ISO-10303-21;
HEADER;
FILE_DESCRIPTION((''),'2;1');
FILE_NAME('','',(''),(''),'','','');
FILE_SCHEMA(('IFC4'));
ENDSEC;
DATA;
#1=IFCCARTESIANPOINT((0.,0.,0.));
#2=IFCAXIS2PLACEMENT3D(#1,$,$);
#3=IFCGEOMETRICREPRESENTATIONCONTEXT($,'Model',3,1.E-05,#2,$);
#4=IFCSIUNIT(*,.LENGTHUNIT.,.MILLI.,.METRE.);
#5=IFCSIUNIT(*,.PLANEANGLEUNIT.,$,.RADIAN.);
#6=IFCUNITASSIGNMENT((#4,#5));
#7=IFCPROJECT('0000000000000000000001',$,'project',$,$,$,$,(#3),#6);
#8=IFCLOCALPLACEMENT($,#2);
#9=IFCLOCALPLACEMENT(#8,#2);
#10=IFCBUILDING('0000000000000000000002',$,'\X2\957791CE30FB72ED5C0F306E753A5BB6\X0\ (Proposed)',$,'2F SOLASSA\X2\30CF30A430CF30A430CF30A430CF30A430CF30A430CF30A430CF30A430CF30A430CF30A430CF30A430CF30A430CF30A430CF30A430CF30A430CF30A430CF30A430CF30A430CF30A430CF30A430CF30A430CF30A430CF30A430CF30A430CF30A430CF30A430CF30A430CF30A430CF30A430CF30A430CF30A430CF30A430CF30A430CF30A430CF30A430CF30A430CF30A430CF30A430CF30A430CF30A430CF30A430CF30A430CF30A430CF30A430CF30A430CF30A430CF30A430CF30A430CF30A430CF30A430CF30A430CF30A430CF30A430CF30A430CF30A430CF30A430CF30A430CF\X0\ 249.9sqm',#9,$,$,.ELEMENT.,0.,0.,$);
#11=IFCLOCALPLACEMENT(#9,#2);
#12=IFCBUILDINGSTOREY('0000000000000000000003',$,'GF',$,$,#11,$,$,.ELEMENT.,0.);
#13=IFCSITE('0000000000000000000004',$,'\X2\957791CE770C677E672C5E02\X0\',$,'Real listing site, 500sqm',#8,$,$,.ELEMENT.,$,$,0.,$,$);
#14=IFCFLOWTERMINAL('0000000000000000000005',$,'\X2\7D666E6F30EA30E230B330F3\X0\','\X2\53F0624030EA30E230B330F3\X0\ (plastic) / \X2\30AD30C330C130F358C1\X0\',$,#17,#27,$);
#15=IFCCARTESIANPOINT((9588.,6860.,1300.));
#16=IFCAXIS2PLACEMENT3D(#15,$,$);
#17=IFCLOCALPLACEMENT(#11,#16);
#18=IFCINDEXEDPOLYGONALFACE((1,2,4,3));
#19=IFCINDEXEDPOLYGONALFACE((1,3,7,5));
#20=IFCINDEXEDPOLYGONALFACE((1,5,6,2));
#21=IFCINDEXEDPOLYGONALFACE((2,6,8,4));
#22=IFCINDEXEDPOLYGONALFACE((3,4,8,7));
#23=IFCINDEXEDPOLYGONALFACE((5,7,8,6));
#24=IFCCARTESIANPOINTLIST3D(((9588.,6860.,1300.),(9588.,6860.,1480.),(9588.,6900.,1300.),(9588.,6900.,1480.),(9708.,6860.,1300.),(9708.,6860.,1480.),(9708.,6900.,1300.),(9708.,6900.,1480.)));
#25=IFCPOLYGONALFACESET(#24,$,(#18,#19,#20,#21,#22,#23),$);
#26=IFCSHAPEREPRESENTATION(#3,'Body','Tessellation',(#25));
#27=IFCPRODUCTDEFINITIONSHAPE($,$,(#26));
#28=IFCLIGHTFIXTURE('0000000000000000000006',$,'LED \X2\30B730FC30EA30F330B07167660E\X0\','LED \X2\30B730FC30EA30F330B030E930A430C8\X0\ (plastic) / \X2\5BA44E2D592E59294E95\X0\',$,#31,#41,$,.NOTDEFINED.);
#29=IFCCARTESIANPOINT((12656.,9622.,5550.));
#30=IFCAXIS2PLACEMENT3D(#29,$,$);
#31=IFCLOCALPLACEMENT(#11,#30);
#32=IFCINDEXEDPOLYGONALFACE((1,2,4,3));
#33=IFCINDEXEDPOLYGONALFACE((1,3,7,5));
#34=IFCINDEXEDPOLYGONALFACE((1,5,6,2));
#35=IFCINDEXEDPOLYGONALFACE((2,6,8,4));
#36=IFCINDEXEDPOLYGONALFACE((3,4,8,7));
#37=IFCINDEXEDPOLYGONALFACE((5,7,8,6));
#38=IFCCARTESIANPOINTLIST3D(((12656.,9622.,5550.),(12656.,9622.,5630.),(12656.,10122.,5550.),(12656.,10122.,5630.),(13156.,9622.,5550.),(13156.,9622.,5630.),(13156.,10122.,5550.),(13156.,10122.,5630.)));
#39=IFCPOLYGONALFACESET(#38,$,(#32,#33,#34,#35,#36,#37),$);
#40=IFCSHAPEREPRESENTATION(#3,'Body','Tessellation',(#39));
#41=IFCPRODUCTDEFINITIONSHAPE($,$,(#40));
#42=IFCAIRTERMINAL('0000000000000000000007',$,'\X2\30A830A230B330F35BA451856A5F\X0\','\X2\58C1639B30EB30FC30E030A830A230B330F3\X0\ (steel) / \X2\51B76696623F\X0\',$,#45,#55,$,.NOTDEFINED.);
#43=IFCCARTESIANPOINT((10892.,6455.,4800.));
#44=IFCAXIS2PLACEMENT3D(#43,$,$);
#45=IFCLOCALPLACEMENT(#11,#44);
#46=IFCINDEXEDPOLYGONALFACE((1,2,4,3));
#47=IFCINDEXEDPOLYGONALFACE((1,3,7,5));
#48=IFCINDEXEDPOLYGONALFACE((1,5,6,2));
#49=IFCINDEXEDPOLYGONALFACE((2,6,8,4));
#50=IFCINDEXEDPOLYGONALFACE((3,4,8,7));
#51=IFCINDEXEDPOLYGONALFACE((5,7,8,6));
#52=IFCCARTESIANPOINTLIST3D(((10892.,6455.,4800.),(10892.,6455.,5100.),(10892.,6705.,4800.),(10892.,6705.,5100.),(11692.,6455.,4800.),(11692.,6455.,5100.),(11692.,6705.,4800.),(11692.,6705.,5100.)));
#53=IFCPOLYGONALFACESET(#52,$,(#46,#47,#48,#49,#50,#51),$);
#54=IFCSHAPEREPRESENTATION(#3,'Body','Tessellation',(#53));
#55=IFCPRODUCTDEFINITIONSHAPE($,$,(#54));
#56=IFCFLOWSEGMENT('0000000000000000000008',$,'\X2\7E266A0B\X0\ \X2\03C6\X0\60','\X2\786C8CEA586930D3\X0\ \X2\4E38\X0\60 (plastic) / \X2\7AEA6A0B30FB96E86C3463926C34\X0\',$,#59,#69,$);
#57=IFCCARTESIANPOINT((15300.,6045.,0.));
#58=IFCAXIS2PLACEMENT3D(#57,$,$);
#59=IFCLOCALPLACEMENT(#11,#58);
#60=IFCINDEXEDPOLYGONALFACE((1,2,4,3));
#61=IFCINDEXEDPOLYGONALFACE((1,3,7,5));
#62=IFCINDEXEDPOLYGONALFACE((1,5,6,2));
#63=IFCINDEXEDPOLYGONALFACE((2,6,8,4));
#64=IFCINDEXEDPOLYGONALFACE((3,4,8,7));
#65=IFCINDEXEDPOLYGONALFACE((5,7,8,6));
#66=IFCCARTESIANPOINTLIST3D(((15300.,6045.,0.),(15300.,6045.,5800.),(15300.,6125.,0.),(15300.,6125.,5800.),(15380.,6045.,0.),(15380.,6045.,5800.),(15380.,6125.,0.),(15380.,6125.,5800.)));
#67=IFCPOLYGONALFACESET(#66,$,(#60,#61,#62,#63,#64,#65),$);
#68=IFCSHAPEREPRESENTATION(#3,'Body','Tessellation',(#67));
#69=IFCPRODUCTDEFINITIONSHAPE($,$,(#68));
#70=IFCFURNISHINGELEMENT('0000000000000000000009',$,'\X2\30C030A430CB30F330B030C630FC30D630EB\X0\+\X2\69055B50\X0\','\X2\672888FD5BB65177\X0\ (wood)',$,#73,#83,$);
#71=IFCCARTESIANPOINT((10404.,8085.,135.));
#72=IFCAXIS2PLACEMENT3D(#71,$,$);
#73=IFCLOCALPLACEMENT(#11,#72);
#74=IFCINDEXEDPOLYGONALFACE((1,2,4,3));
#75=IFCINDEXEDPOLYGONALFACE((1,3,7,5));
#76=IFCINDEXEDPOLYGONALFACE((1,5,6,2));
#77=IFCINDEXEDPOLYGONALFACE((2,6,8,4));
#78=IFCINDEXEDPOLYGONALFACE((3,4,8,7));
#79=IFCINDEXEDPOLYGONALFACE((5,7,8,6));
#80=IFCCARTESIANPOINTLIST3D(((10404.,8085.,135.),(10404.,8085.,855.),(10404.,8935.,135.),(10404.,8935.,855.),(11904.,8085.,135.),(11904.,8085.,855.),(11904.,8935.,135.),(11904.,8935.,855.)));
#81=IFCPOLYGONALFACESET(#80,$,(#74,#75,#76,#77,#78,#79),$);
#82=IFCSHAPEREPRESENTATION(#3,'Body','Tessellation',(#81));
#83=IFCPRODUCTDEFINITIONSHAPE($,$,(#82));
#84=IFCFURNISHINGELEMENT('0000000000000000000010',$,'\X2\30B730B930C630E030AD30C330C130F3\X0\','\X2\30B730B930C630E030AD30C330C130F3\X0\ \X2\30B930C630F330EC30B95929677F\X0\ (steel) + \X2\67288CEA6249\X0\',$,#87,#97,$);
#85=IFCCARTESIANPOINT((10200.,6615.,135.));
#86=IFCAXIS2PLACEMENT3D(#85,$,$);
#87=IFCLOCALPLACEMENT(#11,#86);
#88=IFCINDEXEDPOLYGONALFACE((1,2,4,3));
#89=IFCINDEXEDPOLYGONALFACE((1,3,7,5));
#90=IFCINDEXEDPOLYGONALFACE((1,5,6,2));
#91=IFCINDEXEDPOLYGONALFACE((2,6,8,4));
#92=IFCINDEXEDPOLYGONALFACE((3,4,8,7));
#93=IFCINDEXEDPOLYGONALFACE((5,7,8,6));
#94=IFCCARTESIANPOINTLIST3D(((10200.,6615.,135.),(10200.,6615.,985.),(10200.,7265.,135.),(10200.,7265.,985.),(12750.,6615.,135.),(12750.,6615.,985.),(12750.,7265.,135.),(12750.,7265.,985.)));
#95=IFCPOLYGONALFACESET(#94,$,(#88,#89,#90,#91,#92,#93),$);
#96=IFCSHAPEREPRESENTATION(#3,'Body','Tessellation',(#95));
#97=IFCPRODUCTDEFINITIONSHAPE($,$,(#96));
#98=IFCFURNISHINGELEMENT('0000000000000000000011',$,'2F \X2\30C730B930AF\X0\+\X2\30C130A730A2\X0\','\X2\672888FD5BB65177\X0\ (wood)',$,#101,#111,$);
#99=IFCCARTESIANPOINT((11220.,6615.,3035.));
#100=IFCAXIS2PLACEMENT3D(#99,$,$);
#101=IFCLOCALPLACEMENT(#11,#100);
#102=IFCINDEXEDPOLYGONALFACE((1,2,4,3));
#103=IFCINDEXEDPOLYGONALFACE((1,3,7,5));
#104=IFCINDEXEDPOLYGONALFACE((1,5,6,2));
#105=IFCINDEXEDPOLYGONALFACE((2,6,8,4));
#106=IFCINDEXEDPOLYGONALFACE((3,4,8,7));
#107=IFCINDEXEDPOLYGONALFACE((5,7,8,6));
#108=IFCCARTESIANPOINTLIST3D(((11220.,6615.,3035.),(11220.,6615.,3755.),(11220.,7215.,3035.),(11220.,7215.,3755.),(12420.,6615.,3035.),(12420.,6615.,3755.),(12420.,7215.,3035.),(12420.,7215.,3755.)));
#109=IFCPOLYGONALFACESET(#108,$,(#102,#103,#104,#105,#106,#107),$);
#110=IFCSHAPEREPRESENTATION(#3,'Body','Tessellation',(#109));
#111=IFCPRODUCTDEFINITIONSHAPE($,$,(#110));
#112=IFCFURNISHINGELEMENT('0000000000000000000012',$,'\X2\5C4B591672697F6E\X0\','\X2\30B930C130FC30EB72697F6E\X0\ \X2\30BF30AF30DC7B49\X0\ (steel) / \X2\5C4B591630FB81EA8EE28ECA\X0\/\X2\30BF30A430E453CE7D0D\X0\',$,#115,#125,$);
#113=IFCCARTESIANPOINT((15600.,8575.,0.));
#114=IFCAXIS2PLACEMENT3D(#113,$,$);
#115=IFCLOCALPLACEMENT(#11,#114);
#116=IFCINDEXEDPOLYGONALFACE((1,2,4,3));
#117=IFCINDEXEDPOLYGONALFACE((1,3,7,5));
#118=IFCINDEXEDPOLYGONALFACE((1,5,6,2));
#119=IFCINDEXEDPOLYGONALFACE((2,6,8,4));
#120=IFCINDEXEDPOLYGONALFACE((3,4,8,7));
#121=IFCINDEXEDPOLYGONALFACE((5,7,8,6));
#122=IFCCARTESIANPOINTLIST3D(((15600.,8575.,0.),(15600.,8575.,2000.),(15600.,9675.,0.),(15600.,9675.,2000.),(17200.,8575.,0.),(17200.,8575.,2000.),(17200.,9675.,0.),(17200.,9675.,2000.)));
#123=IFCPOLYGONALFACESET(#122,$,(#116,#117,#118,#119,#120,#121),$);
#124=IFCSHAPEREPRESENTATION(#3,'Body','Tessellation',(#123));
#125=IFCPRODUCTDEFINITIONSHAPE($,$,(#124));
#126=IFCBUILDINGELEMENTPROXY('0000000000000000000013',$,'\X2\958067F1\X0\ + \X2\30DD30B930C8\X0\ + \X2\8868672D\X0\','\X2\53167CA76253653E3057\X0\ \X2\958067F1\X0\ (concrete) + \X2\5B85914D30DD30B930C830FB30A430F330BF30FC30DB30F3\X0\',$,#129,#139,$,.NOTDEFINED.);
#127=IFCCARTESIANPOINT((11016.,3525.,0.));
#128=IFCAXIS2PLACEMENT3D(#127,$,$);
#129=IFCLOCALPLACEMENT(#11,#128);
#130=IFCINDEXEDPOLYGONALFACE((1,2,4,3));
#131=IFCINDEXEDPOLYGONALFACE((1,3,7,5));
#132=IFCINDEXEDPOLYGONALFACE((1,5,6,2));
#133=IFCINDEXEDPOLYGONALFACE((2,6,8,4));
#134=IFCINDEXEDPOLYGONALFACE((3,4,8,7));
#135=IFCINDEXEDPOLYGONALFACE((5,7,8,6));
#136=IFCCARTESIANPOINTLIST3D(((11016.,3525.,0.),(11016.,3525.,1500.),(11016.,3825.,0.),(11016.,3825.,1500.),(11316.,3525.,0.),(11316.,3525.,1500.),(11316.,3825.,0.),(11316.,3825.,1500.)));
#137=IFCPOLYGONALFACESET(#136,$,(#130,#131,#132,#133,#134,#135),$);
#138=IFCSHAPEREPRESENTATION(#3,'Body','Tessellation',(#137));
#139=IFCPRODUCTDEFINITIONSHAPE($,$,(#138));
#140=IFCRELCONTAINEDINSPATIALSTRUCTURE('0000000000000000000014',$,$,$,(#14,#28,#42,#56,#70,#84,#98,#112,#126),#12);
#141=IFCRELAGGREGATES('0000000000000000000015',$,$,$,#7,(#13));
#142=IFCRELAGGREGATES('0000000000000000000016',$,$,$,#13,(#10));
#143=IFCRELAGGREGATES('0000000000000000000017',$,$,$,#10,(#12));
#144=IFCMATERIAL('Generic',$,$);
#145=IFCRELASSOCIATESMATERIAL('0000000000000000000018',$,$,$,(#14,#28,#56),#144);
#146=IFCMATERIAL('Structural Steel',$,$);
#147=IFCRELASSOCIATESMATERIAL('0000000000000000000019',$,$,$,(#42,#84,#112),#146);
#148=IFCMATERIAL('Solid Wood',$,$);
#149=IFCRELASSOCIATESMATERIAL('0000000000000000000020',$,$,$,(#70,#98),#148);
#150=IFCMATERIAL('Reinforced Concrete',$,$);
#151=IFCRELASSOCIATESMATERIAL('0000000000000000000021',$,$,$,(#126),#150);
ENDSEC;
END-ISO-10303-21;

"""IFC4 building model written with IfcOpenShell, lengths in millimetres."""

from ifc_helpers import new_model, si_unit, frame, frame_2d, origin, place, context, project, spatial, rectangle, extrude, material, element, save


model = new_model("IFC4")

# Units and contexts
model_context = context("Model", 3, precision=1e-05, world=origin())
ifc_project = project(units=[si_unit("LENGTHUNIT", "METRE", prefix="MILLI"), si_unit("PLANEANGLEUNIT", "RADIAN")], contexts=[model_context])

# Site, building, storey
site_placement = place(None, origin())
site = spatial("IfcSite", under=ifc_project, at=site_placement, Name="長野県松本市", ObjectType="Real listing site, 500sqm", CompositionType="ELEMENT", RefElevation=0.0)
building_placement = place(site_placement, origin())
building = spatial("IfcBuilding", under=site, at=building_placement, Name="長野・狭小の町家 (Proposed)", ObjectType="2F SOLASSAハイハイハイハイハイハイハイハイハイハイハイハイハイハイハイハイハイハイハイハイハイハイハイハイハイハイハイハイハイハイハイハイハイハイハイハイハイハイハイハイハイハイハイハイハイハイハイハイハイハイハイハイハイハイハイハイハ 249.9sqm", CompositionType="ELEMENT", ElevationOfRefHeight=0.0, ElevationOfTerrain=0.0)
storey_placement = place(building_placement, origin())
storey = spatial("IfcBuildingStorey", under=building, at=storey_placement, Name="GF", CompositionType="ELEMENT", Elevation=0.0)

# Shared definitions
ifc_material_1 = material(Name="Solid Wood")

# Shared definitions
ifc_material_2 = material(Name="Reinforced Concrete")

# Shared definitions
ifc_material_3 = material(Name="Structural Steel")

# Flow terminal
ifc_material_4 = material(Name="Generic")
flow_terminal_1_placement = place(storey_placement, frame((9588.0, 6860.0, 1300.0)))
element("IfcFlowTerminal", 1, at=flow_terminal_1_placement, inside=storey, material=ifc_material_4, Name="給湯リモコン", Description="台所リモコン (plastic) / キッチン壁", context=model_context, shape_type="SweptSolid", body=[
    extrude(rectangle(XDim=120.0, YDim=40.0, at=frame_2d((60.0, 20.0))), frame((9588.0, 6860.0, 1300.0)), (0.0, 0.0, 1.0), 180.0),
])

# Light fixture
light_fixture_placement = place(storey_placement, frame((12656.0, 9622.0, 5550.0)))
element("IfcLightFixture", 2, at=light_fixture_placement, inside=storey, material=ifc_material_4, Name="LED シーリング照明", Description="LED シーリングライト (plastic) / 室中央天井", PredefinedType="NOTDEFINED", context=model_context, shape_type="SweptSolid", body=[
    extrude(rectangle(XDim=500.0, YDim=500.0, at=frame_2d((250.0, 250.0))), frame((12656.0, 9622.0, 5550.0)), (0.0, 0.0, 1.0), 80.0),
])

# Air terminal
air_terminal_placement = place(storey_placement, frame((10892.0, 6455.0, 4800.0)))
element("IfcAirTerminal", 3, at=air_terminal_placement, inside=storey, material=ifc_material_3, Name="エアコン室内機", Description="壁掛ルームエアコン (steel) / 冷暖房", PredefinedType="NOTDEFINED", context=model_context, shape_type="SweptSolid", body=[
    extrude(rectangle(XDim=800.0, YDim=250.0, at=frame_2d((400.0, 125.0))), frame((10892.0, 6455.0, 4800.0)), (0.0, 0.0, 1.0), 300.0),
])

# Flow segment
flow_segment_placement = place(storey_placement, frame((15300.0, 6045.0, 0.0)))
element("IfcFlowSegment", 4, at=flow_segment_placement, inside=storey, material=ifc_material_4, Name="縦樋 φ60", Description="硬質塩ビ 丸60 (plastic) / 竪樋・雨水排水", context=model_context, shape_type="SweptSolid", body=[
    extrude(rectangle(XDim=80.0, YDim=80.0, at=frame_2d((40.0, 40.0))), frame((15300.0, 6045.0, 0.0)), (0.0, 0.0, 1.0), 5800.0),
])

# Furnishing elements
furnishing_1_placement = place(storey_placement, frame((10404.0, 8085.0, 135.0)))
element("IfcFurnishingElement", 5, at=furnishing_1_placement, inside=storey, material=ifc_material_1, Name="ダイニングテーブル+椅子", Description="木製家具 (wood)", context=model_context, shape_type="SweptSolid", body=[
    extrude(rectangle(XDim=1500.0, YDim=850.0, at=frame_2d((750.0, 425.0))), frame((10404.0, 8085.0, 135.0)), (0.0, 0.0, 1.0), 720.0),
])
furnishing_2_placement = place(storey_placement, frame((10200.0, 6615.0, 135.0)))
element("IfcFurnishingElement", 6, at=furnishing_2_placement, inside=storey, material=ifc_material_3, Name="システムキッチン", Description="システムキッチン ステンレス天板 (steel) + 木質扉", context=model_context, shape_type="SweptSolid", body=[
    extrude(rectangle(XDim=2550.0, YDim=650.0, at=frame_2d((1275.0, 325.0))), frame((10200.0, 6615.0, 135.0)), (0.0, 0.0, 1.0), 850.0),
])
furnishing_3_placement = place(storey_placement, frame((11220.0, 6615.0, 3035.0)))
element("IfcFurnishingElement", 7, at=furnishing_3_placement, inside=storey, material=ifc_material_1, Name="2F デスク+チェア", Description="木製家具 (wood)", context=model_context, shape_type="SweptSolid", body=[
    extrude(rectangle(XDim=1200.0, YDim=600.0, at=frame_2d((600.0, 300.0))), frame((11220.0, 6615.0, 3035.0)), (0.0, 0.0, 1.0), 720.0),
])
furnishing_4_placement = place(storey_placement, frame((15600.0, 8575.0, 0.0)))
element("IfcFurnishingElement", 8, at=furnishing_4_placement, inside=storey, material=ifc_material_3, Name="屋外物置", Description="スチール物置 タクボ等 (steel) / 屋外・自転車/タイヤ収納", context=model_context, shape_type="SweptSolid", body=[
    extrude(rectangle(XDim=1600.0, YDim=1100.0, at=frame_2d((800.0, 550.0))), frame((15600.0, 8575.0, 0.0)), (0.0, 0.0, 1.0), 2000.0),
])

# Building element proxy
proxy_placement = place(storey_placement, frame((11016.0, 3525.0, 0.0)))
element("IfcBuildingElementProxy", 9, at=proxy_placement, inside=storey, material=ifc_material_2, Name="門柱 + ポスト + 表札", Description="化粧打放し 門柱 (concrete) + 宅配ポスト・インターホン", PredefinedType="NOTDEFINED", context=model_context, shape_type="SweptSolid", body=[
    extrude(rectangle(XDim=300.0, YDim=300.0, at=frame_2d((150.0, 150.0))), frame((11016.0, 3525.0, 0.0)), (0.0, 0.0, 1.0), 1500.0),
])

save(model, "model.ifc")
